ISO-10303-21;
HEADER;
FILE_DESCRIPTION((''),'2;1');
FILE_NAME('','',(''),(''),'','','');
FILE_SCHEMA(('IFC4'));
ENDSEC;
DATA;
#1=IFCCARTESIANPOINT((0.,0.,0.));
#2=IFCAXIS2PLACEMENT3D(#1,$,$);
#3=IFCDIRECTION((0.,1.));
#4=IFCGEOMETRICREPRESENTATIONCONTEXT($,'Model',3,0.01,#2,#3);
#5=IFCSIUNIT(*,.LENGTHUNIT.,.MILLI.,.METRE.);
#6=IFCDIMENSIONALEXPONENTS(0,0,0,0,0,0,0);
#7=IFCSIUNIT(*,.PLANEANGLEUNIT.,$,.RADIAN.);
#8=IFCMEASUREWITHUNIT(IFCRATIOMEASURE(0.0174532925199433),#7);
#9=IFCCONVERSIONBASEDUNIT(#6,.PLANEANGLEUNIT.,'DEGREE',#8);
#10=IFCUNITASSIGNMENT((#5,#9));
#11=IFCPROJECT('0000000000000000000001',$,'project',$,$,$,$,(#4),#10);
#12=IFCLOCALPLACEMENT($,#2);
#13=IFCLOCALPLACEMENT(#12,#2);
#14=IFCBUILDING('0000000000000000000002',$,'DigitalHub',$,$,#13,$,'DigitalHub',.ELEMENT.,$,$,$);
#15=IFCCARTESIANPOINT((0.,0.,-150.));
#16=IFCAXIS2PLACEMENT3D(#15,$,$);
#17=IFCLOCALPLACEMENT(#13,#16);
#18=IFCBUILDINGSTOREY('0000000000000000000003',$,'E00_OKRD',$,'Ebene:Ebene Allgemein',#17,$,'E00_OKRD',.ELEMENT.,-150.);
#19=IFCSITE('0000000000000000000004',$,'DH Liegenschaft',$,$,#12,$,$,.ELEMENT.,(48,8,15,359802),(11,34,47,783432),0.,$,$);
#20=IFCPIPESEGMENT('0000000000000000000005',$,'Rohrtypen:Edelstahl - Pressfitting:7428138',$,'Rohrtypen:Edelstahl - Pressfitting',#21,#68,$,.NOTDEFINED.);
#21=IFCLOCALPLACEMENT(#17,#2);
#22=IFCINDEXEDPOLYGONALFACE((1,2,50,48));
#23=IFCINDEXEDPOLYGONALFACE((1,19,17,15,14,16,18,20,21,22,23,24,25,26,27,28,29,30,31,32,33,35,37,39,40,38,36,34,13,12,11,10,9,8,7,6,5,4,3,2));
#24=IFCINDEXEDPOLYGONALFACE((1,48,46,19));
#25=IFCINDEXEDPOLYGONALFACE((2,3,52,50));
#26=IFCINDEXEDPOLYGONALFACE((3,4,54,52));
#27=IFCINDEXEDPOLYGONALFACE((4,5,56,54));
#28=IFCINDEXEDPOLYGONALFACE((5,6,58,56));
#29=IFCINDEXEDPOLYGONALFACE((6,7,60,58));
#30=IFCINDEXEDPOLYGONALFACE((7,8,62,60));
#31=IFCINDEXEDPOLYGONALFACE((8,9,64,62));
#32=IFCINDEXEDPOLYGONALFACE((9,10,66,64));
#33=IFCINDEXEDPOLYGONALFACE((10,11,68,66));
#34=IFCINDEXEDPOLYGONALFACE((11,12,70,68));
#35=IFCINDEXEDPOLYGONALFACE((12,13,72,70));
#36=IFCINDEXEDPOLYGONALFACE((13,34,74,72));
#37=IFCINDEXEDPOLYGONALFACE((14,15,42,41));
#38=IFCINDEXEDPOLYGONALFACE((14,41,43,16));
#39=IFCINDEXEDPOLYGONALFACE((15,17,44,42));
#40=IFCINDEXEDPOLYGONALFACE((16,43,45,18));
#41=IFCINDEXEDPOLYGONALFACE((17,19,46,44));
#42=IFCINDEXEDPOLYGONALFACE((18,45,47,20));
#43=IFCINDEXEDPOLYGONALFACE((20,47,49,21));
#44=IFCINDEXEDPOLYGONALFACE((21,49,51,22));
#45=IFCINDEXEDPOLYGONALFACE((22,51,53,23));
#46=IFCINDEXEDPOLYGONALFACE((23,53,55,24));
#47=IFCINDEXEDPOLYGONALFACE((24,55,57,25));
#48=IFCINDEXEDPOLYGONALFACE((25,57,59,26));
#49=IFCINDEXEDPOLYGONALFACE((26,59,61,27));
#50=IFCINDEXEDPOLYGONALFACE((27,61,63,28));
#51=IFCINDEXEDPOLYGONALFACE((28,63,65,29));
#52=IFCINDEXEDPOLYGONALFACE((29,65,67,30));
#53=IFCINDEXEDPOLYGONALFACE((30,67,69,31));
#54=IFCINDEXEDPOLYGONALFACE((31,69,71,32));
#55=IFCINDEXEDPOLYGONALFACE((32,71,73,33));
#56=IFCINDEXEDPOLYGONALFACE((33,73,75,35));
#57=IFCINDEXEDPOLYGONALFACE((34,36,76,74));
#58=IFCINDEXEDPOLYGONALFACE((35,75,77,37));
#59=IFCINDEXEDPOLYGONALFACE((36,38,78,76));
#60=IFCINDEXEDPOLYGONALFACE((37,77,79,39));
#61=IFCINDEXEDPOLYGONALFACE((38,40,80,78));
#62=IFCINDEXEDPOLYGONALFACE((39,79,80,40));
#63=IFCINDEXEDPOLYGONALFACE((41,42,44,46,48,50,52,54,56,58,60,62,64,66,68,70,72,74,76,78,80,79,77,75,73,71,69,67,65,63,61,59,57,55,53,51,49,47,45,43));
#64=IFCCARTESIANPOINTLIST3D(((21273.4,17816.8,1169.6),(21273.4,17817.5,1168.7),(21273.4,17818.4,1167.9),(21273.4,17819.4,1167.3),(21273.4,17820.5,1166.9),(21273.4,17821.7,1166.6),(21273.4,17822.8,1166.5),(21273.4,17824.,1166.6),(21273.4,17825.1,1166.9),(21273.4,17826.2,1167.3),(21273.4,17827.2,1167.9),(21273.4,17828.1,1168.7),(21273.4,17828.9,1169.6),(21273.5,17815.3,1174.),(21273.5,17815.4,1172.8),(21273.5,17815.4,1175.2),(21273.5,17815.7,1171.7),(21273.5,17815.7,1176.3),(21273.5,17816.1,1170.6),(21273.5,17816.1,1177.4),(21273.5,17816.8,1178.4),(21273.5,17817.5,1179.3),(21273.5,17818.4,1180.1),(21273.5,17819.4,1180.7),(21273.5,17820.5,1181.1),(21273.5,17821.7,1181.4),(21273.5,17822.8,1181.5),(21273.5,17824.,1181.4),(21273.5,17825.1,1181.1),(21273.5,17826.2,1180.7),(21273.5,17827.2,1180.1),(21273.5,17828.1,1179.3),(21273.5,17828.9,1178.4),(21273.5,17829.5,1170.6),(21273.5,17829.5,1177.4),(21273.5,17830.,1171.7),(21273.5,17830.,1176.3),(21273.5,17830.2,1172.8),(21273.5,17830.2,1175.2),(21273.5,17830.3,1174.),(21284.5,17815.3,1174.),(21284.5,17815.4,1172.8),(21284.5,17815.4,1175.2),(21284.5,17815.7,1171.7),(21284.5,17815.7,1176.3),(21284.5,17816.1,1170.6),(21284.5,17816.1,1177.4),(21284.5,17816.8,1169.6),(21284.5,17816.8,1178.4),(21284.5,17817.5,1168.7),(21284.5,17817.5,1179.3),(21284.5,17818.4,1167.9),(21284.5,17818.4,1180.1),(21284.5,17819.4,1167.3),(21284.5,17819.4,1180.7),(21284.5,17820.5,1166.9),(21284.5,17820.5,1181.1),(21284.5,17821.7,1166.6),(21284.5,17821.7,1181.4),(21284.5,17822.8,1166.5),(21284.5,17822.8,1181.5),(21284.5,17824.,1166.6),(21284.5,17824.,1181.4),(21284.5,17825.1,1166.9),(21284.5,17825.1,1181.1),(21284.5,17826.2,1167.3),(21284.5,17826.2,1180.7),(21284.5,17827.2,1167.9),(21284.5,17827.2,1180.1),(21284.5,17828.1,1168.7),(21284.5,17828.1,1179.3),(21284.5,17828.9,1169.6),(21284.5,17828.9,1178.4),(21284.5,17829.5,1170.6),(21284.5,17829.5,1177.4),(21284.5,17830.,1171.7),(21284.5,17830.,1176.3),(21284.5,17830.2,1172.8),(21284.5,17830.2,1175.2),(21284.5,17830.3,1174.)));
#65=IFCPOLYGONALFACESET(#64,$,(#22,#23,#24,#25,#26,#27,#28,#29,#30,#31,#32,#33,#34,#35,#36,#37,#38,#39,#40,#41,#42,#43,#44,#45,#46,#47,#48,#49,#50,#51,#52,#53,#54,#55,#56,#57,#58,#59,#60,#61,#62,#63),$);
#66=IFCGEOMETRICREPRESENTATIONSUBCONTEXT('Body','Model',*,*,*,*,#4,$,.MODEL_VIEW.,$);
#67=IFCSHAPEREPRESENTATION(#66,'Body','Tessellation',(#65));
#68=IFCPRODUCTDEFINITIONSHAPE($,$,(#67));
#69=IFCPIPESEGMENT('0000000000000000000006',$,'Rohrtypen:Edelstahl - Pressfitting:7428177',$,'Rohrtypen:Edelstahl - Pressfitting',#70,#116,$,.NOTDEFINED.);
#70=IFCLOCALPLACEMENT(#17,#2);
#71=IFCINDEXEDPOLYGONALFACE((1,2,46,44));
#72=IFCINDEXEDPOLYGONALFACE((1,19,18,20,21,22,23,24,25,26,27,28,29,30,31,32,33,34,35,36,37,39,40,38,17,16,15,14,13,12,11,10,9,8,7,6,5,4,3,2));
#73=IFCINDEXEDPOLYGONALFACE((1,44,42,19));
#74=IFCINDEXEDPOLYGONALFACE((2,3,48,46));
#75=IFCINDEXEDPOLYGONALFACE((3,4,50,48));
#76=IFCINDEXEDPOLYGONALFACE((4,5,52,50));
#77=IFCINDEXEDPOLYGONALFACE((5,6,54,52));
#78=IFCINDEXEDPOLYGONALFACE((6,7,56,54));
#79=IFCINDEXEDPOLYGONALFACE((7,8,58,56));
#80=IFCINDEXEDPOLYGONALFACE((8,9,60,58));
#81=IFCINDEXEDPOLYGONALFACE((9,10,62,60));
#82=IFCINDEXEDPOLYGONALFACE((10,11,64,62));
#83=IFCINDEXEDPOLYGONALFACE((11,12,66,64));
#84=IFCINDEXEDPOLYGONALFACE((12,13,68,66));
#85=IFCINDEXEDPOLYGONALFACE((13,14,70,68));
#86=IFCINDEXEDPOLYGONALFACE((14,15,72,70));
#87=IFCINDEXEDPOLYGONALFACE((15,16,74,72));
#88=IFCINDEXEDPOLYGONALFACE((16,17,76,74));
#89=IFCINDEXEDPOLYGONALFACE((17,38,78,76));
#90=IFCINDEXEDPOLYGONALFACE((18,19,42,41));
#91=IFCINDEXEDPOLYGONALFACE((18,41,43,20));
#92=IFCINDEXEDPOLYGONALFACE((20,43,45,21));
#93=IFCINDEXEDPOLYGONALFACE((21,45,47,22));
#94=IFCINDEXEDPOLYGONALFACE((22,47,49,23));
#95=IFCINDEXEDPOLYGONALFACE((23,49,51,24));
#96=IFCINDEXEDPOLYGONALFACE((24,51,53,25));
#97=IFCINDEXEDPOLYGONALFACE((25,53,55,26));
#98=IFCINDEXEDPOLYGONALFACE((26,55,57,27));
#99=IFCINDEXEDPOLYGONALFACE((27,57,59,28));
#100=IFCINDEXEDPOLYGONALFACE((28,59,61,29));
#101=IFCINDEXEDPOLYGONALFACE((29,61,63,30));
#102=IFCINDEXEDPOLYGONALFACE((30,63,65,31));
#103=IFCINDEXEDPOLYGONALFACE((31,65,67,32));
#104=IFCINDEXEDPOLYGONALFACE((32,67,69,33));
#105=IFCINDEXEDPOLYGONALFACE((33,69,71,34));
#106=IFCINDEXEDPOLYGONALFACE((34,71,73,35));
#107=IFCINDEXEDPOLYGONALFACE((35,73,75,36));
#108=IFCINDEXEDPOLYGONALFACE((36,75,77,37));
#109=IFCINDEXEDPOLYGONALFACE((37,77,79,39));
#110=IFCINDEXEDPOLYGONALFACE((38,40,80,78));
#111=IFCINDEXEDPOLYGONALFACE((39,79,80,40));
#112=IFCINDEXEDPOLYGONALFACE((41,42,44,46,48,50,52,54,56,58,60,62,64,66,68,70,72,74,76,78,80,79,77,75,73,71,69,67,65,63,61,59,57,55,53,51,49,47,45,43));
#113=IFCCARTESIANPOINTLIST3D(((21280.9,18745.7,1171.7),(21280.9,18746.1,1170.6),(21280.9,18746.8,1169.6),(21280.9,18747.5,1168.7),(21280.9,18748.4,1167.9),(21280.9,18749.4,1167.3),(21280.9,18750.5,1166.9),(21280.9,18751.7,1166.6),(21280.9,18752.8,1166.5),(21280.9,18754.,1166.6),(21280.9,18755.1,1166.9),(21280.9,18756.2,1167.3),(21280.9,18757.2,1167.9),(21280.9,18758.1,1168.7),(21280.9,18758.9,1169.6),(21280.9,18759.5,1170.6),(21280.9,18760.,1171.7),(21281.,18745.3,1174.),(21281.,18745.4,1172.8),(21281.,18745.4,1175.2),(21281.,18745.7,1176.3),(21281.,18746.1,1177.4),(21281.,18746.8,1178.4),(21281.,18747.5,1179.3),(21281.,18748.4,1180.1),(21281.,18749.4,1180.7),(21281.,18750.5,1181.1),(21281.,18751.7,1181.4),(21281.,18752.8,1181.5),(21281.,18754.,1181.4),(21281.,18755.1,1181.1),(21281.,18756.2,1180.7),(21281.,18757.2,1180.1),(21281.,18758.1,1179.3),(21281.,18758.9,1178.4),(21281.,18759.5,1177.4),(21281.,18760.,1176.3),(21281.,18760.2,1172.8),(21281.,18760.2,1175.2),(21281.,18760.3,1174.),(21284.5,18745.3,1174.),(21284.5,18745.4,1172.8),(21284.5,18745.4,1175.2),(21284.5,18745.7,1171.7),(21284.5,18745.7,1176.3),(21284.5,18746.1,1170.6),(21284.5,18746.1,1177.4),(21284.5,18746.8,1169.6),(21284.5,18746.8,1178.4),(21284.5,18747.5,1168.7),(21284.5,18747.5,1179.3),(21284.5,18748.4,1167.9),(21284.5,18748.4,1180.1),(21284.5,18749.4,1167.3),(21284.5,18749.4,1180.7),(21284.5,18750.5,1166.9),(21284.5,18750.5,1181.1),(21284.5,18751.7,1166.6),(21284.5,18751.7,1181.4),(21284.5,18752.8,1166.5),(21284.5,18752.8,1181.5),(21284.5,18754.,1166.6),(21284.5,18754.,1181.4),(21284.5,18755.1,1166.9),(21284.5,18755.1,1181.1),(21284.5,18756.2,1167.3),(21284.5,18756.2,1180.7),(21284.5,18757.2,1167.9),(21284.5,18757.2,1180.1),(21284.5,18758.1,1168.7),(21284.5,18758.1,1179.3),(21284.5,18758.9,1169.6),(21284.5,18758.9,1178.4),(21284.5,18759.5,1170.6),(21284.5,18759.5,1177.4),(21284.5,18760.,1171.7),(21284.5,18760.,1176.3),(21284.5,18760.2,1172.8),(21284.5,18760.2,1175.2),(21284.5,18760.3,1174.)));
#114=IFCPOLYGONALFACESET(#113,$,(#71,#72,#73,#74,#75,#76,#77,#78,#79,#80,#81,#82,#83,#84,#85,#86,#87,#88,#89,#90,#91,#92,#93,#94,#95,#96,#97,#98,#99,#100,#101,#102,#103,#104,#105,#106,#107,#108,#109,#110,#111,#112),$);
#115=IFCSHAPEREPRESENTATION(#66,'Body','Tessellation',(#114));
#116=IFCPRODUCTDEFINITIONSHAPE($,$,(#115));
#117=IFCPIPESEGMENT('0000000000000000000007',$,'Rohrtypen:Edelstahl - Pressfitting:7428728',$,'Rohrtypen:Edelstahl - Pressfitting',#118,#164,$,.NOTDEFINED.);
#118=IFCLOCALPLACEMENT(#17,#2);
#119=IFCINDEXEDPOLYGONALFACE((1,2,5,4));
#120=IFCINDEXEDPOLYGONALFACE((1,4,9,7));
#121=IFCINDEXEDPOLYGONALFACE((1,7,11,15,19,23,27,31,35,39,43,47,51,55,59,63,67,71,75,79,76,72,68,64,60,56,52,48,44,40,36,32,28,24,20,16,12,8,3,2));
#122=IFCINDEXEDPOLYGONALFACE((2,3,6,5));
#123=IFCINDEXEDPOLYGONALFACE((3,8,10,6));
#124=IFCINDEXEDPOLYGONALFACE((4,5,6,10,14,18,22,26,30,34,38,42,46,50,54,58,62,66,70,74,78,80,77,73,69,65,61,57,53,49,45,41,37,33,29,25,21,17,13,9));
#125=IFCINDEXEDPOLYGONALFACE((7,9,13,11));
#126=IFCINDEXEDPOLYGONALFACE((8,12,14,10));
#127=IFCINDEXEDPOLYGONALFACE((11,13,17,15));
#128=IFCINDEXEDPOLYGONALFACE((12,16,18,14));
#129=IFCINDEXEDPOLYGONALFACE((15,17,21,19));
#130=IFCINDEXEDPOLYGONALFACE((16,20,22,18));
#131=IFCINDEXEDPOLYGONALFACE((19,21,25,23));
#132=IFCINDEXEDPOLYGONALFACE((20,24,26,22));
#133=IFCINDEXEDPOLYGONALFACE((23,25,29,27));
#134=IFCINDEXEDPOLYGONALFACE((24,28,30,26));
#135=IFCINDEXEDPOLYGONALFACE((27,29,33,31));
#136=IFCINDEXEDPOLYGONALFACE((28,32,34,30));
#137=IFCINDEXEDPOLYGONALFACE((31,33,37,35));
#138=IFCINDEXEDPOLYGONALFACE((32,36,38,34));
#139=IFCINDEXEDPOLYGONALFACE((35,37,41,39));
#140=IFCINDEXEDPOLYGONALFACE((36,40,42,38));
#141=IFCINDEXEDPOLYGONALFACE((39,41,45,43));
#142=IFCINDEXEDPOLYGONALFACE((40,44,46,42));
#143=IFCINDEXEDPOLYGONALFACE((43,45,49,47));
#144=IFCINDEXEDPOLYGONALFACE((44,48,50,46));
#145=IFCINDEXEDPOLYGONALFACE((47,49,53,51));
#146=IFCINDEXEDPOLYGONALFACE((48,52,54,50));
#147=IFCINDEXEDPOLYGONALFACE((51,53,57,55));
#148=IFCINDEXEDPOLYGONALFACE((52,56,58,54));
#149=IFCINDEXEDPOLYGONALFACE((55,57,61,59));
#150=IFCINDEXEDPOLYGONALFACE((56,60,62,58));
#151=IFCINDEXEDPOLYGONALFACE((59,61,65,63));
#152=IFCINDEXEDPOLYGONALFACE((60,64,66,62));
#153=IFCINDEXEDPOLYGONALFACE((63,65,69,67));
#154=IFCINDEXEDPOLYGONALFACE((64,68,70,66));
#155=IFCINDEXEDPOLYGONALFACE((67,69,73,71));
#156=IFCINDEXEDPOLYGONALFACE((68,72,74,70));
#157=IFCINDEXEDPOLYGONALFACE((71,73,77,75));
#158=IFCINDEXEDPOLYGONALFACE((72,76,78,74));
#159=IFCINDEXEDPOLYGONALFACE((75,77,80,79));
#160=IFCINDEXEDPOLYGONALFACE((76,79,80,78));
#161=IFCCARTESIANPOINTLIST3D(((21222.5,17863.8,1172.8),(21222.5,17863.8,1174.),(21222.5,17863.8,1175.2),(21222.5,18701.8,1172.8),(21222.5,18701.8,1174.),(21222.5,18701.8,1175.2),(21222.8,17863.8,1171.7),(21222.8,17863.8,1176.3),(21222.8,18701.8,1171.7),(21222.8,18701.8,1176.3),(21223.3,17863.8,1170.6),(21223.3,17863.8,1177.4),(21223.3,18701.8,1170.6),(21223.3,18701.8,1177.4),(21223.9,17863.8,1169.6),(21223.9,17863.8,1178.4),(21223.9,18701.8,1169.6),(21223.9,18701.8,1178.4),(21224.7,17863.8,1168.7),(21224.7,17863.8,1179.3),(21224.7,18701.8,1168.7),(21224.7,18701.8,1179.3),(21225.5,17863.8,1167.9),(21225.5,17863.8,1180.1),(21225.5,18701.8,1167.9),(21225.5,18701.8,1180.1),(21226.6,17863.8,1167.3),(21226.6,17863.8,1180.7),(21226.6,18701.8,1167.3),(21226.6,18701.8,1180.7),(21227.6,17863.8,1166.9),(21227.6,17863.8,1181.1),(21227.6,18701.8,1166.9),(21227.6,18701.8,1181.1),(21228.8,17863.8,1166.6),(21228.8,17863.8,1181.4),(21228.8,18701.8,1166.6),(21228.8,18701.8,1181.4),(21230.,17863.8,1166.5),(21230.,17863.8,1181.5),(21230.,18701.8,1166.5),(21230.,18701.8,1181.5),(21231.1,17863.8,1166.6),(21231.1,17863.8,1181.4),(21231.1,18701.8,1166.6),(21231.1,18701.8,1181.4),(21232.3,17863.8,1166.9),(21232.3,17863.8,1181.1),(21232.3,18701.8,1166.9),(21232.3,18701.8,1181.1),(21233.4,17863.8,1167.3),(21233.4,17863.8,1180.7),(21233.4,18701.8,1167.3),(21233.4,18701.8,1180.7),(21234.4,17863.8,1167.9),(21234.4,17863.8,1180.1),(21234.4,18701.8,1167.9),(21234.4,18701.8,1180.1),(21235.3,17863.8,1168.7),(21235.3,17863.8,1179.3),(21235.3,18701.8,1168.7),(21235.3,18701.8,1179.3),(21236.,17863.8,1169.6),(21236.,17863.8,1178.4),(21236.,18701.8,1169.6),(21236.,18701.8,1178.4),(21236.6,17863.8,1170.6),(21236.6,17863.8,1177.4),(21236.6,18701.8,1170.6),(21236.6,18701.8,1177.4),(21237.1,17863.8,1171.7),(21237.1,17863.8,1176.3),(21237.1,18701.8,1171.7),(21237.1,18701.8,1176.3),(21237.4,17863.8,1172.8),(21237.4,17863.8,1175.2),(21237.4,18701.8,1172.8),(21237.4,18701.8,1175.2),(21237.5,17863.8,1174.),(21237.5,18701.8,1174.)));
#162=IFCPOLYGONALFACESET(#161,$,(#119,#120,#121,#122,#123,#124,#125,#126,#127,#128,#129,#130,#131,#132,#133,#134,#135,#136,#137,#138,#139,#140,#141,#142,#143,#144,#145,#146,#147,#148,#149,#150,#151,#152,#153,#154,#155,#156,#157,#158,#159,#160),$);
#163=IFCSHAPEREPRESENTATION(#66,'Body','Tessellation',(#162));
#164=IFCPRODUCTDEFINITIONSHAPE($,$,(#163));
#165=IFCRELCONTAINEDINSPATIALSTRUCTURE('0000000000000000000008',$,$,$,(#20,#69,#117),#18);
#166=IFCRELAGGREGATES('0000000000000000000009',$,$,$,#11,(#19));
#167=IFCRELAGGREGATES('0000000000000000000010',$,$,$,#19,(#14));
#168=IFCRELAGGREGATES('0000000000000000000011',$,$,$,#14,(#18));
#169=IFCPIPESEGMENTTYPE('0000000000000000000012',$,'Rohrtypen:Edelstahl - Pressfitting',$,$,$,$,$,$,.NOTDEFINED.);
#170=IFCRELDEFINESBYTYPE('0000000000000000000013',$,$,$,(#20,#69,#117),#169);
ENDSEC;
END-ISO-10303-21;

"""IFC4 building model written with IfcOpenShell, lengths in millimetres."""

from ifc_helpers import new_model, entity, si_unit, converted_unit, direction, frame, origin, place, context, subcontext, project, spatial, indexed_curve, outline, extrude, type_object, element, save


model = new_model("IFC4")

# Units and contexts
model_context = context("Model", 3, precision=0.01, world=origin(), true_north=direction((0.0, 1.0)))
body_context = subcontext(model_context, "Body", "Model", "MODEL_VIEW")
ifc_project = project(units=[si_unit("LENGTHUNIT", "METRE", prefix="MILLI"), converted_unit("PLANEANGLEUNIT", "DEGREE", entity("IfcRatioMeasure", 0.0174532925199433), si_unit("PLANEANGLEUNIT", "RADIAN"), dimensions=[0, 0, 0, 0, 0, 0, 0])], contexts=[model_context])

# Site, building, storey
site_placement = place(None, origin())
site = spatial("IfcSite", under=ifc_project, at=site_placement, Name="DH Liegenschaft", CompositionType="ELEMENT", RefLatitude=(48, 8, 15, 359802), RefLongitude=(11, 34, 47, 783432), RefElevation=0.0)
building_placement = place(site_placement, origin())
building = spatial("IfcBuilding", under=site, at=building_placement, Name="DigitalHub", LongName="DigitalHub", CompositionType="ELEMENT")
storey_placement = place(building_placement, frame((0.0, 0.0, -150.0)))
storey = spatial("IfcBuildingStorey", under=building, at=storey_placement, Name="E00_OKRD", ObjectType="Ebene:Ebene Allgemein", LongName="E00_OKRD", CompositionType="ELEMENT", Elevation=-150.0)

# Pipe segments
pipe_segment_type_1 = type_object("IfcPipeSegmentType", Name="Rohrtypen:Edelstahl - Pressfitting", PredefinedType="NOTDEFINED")
pipe_segment_1_placement = place(storey_placement, frame((21273.4, 17813.7, 1164.9)))
element("IfcPipeSegment", 1, at=pipe_segment_1_placement, inside=storey, type_object=pipe_segment_type_1, Name="Rohrtypen:Edelstahl - Pressfitting:7428138", ObjectType="Rohrtypen:Edelstahl - Pressfitting", PredefinedType="NOTDEFINED", context=body_context, shape_type="SweptSolid", body=[
    extrude(outline(indexed_curve([(7.5, 0.0), (7.4, 1.2), (7.1, 2.3), (6.7, 3.4), (6.1, 4.4), (5.3, 5.3), (4.4, 6.1), (3.4, 6.7), (2.3, 7.1), (1.2, 7.4), (0.0, 7.5), (-1.2, 7.4), (-2.3, 7.1), (-3.4, 6.7), (-4.4, 6.1), (-5.3, 5.3), (-6.1, 4.4), (-6.7, 3.4), (-7.1, 2.3), (-7.4, 1.2), (-7.5, 0.0), (-7.4, -1.2), (-7.1, -2.3), (-6.7, -3.4), (-6.1, -4.4), (-5.3, -5.3), (-4.4, -6.1), (-3.4, -6.7), (-2.3, -7.1), (-1.2, -7.4), (0.0, -7.5), (1.2, -7.4), (2.3, -7.1), (3.4, -6.7), (4.4, -6.1), (5.3, -5.3), (6.1, -4.4), (6.7, -3.4), (7.1, -2.3), (7.4, -1.2), (7.5, 0.0)], self_intersect=False)), frame((0.0, 9.1, 9.1), z_axis=(0.999999, 0.0, -0.001254), x_axis=(0.0, -1.0, 0.0)), (0.0, 0.0, 1.0), 11.1),
])
pipe_segment_2_placement = place(storey_placement, frame((21280.9, 18743.7, 1164.9)))
element("IfcPipeSegment", 2, at=pipe_segment_2_placement, inside=storey, type_object=pipe_segment_type_1, Name="Rohrtypen:Edelstahl - Pressfitting:7428177", ObjectType="Rohrtypen:Edelstahl - Pressfitting", PredefinedType="NOTDEFINED", context=body_context, shape_type="SweptSolid", body=[
    extrude(outline(indexed_curve([(7.5, 0.0), (7.4, 1.2), (7.1, 2.3), (6.7, 3.4), (6.1, 4.4), (5.3, 5.3), (4.4, 6.1), (3.4, 6.7), (2.3, 7.1), (1.2, 7.4), (0.0, 7.5), (-1.2, 7.4), (-2.3, 7.1), (-3.4, 6.7), (-4.4, 6.1), (-5.3, 5.3), (-6.1, 4.4), (-6.7, 3.4), (-7.1, 2.3), (-7.4, 1.2), (-7.5, 0.0), (-7.4, -1.2), (-7.1, -2.3), (-6.7, -3.4), (-6.1, -4.4), (-5.3, -5.3), (-4.4, -6.1), (-3.4, -6.7), (-2.3, -7.1), (-1.2, -7.4), (0.0, -7.5), (1.2, -7.4), (2.3, -7.1), (3.4, -6.7), (4.4, -6.1), (5.3, -5.3), (6.1, -4.4), (6.7, -3.4), (7.1, -2.3), (7.4, -1.2), (7.5, 0.0)], self_intersect=False)), frame((0.0, 9.1, 9.1), z_axis=(0.999992, 0.0, -0.003988), x_axis=(0.0, -1.0, 0.0)), (0.0, 0.0, 1.0), 3.6),
])
pipe_segment_3_placement = place(storey_placement, frame((21220.9, 17863.8, 1164.9)))
element("IfcPipeSegment", 3, at=pipe_segment_3_placement, inside=storey, type_object=pipe_segment_type_1, Name="Rohrtypen:Edelstahl - Pressfitting:7428728", ObjectType="Rohrtypen:Edelstahl - Pressfitting", PredefinedType="NOTDEFINED", context=body_context, shape_type="SweptSolid", body=[
    extrude(outline(indexed_curve([(7.5, 0.0), (7.4, 1.2), (7.1, 2.3), (6.7, 3.4), (6.1, 4.4), (5.3, 5.3), (4.4, 6.1), (3.4, 6.7), (2.3, 7.1), (1.2, 7.4), (0.0, 7.5), (-1.2, 7.4), (-2.3, 7.1), (-3.4, 6.7), (-4.4, 6.1), (-5.3, 5.3), (-6.1, 4.4), (-6.7, 3.4), (-7.1, 2.3), (-7.4, 1.2), (-7.5, 0.0), (-7.4, -1.2), (-7.1, -2.3), (-6.7, -3.4), (-6.1, -4.4), (-5.3, -5.3), (-4.4, -6.1), (-3.4, -6.7), (-2.3, -7.1), (-1.2, -7.4), (0.0, -7.5), (1.2, -7.4), (2.3, -7.1), (3.4, -6.7), (4.4, -6.1), (5.3, -5.3), (6.1, -4.4), (6.7, -3.4), (7.1, -2.3), (7.4, -1.2), (7.5, 0.0)], self_intersect=False)), frame((9.1, 0.0, 9.1), z_axis=(0.0, 1.0, 0.0), x_axis=(1.0, 0.0, 0.0)), (0.0, 0.0, 1.0), 838.0),
])

save(model, "model.ifc")
